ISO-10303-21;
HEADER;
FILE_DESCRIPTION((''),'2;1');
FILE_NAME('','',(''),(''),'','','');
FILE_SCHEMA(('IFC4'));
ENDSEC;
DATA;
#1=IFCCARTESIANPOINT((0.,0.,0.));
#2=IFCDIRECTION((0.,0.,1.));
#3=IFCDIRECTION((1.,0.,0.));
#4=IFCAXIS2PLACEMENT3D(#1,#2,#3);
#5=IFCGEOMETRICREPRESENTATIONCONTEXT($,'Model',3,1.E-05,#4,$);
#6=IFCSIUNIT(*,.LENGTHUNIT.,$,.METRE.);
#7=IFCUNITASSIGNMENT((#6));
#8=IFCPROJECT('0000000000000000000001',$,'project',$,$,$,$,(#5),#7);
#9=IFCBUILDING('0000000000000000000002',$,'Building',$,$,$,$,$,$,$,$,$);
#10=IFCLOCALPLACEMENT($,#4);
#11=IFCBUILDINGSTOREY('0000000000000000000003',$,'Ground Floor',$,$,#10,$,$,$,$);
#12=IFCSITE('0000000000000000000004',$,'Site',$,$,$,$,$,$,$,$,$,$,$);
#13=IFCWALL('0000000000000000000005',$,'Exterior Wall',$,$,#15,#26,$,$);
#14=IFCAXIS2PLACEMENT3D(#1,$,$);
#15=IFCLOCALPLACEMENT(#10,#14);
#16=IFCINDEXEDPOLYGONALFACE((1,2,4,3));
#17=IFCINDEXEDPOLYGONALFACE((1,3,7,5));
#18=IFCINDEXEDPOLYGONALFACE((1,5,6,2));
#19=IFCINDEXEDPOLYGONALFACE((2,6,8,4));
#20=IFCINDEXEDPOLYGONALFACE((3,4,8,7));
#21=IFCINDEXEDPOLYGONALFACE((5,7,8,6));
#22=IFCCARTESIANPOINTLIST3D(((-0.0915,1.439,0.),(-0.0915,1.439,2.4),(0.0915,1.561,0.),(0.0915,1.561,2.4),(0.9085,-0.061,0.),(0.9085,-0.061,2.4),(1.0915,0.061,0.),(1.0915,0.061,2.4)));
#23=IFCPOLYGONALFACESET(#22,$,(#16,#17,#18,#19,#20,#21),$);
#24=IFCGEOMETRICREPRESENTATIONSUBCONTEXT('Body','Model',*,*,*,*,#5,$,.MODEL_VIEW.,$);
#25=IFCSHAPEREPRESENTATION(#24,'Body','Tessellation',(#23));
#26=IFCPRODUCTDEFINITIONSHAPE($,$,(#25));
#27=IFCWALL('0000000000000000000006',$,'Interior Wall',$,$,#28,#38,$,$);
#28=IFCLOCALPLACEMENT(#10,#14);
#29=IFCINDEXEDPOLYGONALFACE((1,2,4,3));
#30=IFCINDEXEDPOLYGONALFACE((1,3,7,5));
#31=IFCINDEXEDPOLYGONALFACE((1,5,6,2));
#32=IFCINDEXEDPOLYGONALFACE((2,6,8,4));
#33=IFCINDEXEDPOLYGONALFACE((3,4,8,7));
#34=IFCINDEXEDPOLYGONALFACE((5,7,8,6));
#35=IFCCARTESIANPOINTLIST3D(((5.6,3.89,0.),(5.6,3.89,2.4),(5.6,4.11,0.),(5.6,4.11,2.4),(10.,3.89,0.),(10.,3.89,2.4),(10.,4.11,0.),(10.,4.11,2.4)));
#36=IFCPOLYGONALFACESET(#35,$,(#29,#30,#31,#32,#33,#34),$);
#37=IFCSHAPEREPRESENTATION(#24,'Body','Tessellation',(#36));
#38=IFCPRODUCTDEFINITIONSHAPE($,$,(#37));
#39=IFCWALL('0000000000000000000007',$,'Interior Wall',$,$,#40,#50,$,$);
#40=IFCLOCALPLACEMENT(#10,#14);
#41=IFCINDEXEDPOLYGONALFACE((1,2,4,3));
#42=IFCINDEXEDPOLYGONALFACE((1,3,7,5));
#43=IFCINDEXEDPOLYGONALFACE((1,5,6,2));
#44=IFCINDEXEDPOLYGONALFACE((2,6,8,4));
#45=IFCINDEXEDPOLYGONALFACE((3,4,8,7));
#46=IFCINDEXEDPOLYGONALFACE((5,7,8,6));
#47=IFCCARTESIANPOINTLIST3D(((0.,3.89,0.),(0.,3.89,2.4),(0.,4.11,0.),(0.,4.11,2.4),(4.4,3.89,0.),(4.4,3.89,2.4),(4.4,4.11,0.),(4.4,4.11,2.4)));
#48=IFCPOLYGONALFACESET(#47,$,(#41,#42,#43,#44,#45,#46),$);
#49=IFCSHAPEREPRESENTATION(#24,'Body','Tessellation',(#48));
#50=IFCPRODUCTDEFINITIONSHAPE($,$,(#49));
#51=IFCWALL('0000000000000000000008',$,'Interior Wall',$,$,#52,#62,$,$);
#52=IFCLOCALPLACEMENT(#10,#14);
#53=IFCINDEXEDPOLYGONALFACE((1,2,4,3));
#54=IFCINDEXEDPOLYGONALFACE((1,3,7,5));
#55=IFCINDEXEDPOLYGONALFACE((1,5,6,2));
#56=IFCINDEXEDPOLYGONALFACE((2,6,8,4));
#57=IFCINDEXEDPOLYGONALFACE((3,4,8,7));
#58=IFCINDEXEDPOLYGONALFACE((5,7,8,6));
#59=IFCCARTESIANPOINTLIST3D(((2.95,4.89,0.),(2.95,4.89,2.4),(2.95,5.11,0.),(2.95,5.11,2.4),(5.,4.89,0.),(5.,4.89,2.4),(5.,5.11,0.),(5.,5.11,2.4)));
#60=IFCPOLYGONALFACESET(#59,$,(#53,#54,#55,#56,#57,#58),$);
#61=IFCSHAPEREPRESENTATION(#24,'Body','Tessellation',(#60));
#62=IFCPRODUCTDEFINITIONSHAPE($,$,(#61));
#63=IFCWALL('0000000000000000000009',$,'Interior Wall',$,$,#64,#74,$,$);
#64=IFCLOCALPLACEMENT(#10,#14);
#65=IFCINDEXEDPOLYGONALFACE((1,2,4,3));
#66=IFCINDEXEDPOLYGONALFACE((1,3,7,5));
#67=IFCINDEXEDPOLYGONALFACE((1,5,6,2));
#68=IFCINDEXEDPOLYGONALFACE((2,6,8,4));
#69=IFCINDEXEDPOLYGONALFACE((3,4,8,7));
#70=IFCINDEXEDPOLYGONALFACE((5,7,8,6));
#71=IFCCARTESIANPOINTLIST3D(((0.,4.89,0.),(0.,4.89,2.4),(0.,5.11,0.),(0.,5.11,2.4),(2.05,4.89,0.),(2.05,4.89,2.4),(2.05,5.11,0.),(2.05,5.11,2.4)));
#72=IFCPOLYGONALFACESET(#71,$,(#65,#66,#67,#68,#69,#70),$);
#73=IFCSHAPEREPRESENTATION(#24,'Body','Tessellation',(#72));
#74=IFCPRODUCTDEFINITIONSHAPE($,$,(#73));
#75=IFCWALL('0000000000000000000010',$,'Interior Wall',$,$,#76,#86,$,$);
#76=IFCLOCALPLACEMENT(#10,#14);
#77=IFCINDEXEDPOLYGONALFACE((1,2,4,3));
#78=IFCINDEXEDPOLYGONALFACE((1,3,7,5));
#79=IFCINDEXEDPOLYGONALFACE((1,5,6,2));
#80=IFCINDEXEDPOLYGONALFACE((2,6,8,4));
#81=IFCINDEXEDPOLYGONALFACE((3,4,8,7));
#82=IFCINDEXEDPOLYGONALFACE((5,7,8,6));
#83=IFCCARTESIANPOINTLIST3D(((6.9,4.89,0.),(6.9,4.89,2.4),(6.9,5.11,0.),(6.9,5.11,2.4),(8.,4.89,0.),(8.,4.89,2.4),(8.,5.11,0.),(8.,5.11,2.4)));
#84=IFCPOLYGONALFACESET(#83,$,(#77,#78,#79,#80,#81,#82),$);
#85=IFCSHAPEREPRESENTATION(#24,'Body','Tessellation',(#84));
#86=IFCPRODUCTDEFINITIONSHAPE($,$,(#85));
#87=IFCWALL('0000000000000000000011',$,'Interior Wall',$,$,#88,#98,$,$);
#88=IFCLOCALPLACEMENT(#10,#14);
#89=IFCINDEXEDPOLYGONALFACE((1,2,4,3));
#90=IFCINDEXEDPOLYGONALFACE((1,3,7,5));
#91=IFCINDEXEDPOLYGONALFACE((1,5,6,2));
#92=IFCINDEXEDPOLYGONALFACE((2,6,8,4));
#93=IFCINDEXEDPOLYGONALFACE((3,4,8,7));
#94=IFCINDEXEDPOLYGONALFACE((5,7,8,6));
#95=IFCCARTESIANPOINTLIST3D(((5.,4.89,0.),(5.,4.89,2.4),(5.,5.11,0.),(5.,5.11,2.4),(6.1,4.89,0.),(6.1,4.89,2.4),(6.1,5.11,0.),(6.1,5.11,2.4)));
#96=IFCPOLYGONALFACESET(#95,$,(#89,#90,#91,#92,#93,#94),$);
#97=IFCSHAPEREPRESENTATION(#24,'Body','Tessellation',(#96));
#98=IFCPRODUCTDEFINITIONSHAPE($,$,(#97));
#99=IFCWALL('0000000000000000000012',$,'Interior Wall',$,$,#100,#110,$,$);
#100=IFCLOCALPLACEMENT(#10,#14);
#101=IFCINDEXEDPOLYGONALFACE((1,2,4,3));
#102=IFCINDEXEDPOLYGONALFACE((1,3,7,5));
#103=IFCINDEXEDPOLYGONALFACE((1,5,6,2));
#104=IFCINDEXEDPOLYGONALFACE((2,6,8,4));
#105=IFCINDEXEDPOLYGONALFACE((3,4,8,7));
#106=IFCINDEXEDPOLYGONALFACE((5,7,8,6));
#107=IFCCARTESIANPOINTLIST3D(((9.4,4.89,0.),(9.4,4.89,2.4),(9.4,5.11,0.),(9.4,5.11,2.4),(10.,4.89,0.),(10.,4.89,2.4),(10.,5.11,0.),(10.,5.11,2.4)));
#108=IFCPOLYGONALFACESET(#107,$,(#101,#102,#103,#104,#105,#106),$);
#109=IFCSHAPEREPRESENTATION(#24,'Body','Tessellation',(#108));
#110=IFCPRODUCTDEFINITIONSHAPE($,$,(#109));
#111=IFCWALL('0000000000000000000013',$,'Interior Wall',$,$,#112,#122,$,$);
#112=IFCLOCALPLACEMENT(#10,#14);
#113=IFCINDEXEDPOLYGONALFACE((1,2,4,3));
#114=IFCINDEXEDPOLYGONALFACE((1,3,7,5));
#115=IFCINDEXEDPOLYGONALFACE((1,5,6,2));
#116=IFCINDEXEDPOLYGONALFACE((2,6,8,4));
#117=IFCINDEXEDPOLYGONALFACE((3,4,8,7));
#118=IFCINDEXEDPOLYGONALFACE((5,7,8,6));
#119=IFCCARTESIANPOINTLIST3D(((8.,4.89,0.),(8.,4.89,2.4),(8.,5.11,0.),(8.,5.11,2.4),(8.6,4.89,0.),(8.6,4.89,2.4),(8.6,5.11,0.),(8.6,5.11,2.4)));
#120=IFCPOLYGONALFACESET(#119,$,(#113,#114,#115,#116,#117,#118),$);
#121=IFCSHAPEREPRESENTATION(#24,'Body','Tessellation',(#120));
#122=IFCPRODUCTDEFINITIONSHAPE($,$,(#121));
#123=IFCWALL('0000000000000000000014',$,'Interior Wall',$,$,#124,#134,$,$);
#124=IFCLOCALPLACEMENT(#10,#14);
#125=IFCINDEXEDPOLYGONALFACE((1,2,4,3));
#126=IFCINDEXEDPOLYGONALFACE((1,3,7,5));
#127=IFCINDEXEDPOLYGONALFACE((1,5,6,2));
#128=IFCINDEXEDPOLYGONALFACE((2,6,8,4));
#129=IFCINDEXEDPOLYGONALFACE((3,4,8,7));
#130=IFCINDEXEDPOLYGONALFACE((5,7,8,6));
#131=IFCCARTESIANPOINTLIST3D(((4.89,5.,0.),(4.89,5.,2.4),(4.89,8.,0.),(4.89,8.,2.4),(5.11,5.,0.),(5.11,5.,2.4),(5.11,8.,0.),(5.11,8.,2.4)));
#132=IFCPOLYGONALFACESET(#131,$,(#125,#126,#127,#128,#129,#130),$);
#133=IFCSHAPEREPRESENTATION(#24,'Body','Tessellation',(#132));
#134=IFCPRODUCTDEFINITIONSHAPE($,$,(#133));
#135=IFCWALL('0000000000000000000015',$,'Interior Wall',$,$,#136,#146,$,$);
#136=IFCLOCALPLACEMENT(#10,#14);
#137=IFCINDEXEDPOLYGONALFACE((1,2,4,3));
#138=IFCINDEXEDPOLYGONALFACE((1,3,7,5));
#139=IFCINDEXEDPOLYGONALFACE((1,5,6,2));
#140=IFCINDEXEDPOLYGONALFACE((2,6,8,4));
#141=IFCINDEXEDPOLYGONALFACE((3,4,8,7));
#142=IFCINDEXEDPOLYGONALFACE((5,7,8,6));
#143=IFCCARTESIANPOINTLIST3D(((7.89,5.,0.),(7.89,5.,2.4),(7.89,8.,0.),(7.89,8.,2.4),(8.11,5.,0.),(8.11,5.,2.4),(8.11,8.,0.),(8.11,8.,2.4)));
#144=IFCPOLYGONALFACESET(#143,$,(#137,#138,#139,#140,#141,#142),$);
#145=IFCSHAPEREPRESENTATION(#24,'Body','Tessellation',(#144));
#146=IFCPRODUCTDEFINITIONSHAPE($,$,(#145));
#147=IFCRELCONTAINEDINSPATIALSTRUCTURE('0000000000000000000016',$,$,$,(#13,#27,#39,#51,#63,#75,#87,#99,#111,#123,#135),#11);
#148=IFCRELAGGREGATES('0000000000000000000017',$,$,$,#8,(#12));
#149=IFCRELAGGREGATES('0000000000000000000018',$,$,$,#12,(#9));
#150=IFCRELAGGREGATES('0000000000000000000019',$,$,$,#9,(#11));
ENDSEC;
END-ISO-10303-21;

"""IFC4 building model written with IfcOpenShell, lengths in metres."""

from ifc_helpers import new_model, si_unit, frame, origin_with_axes, place, context, subcontext, project, spatial, indexed_curve, outline, extrude, element, save


model = new_model("IFC4")

# Units and contexts
model_context = context("Model", 3, precision=1e-05, world=origin_with_axes())
body_context = subcontext(model_context, "Body", "Model", "MODEL_VIEW")
ifc_project = project(units=[si_unit("LENGTHUNIT", "METRE")], contexts=[model_context])

# Site, building, storey
site = spatial("IfcSite", under=ifc_project, Name="Site")
building = spatial("IfcBuilding", under=site, Name="Building")
storey_placement = place(None, origin_with_axes())
storey = spatial("IfcBuildingStorey", under=building, at=storey_placement, Name="Ground Floor")

# Walls
wall_1_placement = place(storey_placement, frame((0.0, 1.5, 0.0), z_axis=(0.0, 0.0, 1.0), x_axis=(0.5547, -0.83205, 0.0)))
element("IfcWall", 1, at=wall_1_placement, inside=storey, Name="Exterior Wall", context=body_context, shape_type="SweptSolid", body=[
    extrude(outline(indexed_curve([(0.0, 0.0), (0.0, 0.22), (1.8028, 0.22), (1.8028, 0.0), (0.0, 0.0)], self_intersect=False)), frame((0.0, -0.11, 0.0), z_axis=(0.0, 0.0, 1.0), x_axis=(1.0, 0.0, 0.0)), (0.0, 0.0, 1.0), 2.4),
])
for number, where, z_axis, x_axis, name in (
    (2, (10.0, 4.0, 0.0), (0.0, 0.0, 1.0), (-1.0, 0.0, 0.0), "Interior Wall"),
    (3, (4.4, 4.0, 0.0), (0.0, 0.0, 1.0), (-1.0, 0.0, 0.0), "Interior Wall"),
):
    element("IfcWall", number, at=place(storey_placement, frame(where, z_axis=z_axis, x_axis=x_axis)), inside=storey, Name=name, context=body_context, shape_type="SweptSolid", body=[
        extrude(outline(indexed_curve([(0.0, 0.0), (0.0, 0.22), (4.4, 0.22), (4.4, 0.0), (0.0, 0.0)], self_intersect=False)), frame((0.0, -0.11, 0.0), z_axis=(0.0, 0.0, 1.0), x_axis=(1.0, 0.0, 0.0)), (0.0, 0.0, 1.0), 2.4),
    ])
for number, where, z_axis, x_axis, name in (
    (4, (5.0, 5.0, 0.0), (0.0, 0.0, 1.0), (-1.0, 0.0, 0.0), "Interior Wall"),
    (5, (2.05, 5.0, 0.0), (0.0, 0.0, 1.0), (-1.0, 0.0, 0.0), "Interior Wall"),
):
    element("IfcWall", number, at=place(storey_placement, frame(where, z_axis=z_axis, x_axis=x_axis)), inside=storey, Name=name, context=body_context, shape_type="SweptSolid", body=[
        extrude(outline(indexed_curve([(0.0, 0.0), (0.0, 0.22), (2.05, 0.22), (2.05, 0.0), (0.0, 0.0)], self_intersect=False)), frame((0.0, -0.11, 0.0), z_axis=(0.0, 0.0, 1.0), x_axis=(1.0, 0.0, 0.0)), (0.0, 0.0, 1.0), 2.4),
    ])
for number, where, z_axis, x_axis, name in (
    (6, (8.0, 5.0, 0.0), (0.0, 0.0, 1.0), (-1.0, 0.0, 0.0), "Interior Wall"),
    (7, (6.1, 5.0, 0.0), (0.0, 0.0, 1.0), (-1.0, 0.0, 0.0), "Interior Wall"),
):
    element("IfcWall", number, at=place(storey_placement, frame(where, z_axis=z_axis, x_axis=x_axis)), inside=storey, Name=name, context=body_context, shape_type="SweptSolid", body=[
        extrude(outline(indexed_curve([(0.0, 0.0), (0.0, 0.22), (1.1, 0.22), (1.1, 0.0), (0.0, 0.0)], self_intersect=False)), frame((0.0, -0.11, 0.0), z_axis=(0.0, 0.0, 1.0), x_axis=(1.0, 0.0, 0.0)), (0.0, 0.0, 1.0), 2.4),
    ])
for number, where, z_axis, x_axis, name in (
    (8, (10.0, 5.0, 0.0), (0.0, 0.0, 1.0), (-1.0, 0.0, 0.0), "Interior Wall"),
    (9, (8.6, 5.0, 0.0), (0.0, 0.0, 1.0), (-1.0, 0.0, 0.0), "Interior Wall"),
):
    element("IfcWall", number, at=place(storey_placement, frame(where, z_axis=z_axis, x_axis=x_axis)), inside=storey, Name=name, context=body_context, shape_type="SweptSolid", body=[
        extrude(outline(indexed_curve([(0.0, 0.0), (0.0, 0.22), (0.6, 0.22), (0.6, 0.0), (0.0, 0.0)], self_intersect=False)), frame((0.0, -0.11, 0.0), z_axis=(0.0, 0.0, 1.0), x_axis=(1.0, 0.0, 0.0)), (0.0, 0.0, 1.0), 2.4),
    ])
for number, where, z_axis, x_axis, name in (
    (10, (5.0, 5.0, 0.0), (0.0, 0.0, 1.0), (0.0, 1.0, 0.0), "Interior Wall"),
    (11, (8.0, 5.0, 0.0), (0.0, 0.0, 1.0), (0.0, 1.0, 0.0), "Interior Wall"),
):
    element("IfcWall", number, at=place(storey_placement, frame(where, z_axis=z_axis, x_axis=x_axis)), inside=storey, Name=name, context=body_context, shape_type="SweptSolid", body=[
        extrude(outline(indexed_curve([(0.0, 0.0), (0.0, 0.22), (3.0, 0.22), (3.0, 0.0), (0.0, 0.0)], self_intersect=False)), frame((0.0, -0.11, 0.0), z_axis=(0.0, 0.0, 1.0), x_axis=(1.0, 0.0, 0.0)), (0.0, 0.0, 1.0), 2.4),
    ])

save(model, "model.ifc")
